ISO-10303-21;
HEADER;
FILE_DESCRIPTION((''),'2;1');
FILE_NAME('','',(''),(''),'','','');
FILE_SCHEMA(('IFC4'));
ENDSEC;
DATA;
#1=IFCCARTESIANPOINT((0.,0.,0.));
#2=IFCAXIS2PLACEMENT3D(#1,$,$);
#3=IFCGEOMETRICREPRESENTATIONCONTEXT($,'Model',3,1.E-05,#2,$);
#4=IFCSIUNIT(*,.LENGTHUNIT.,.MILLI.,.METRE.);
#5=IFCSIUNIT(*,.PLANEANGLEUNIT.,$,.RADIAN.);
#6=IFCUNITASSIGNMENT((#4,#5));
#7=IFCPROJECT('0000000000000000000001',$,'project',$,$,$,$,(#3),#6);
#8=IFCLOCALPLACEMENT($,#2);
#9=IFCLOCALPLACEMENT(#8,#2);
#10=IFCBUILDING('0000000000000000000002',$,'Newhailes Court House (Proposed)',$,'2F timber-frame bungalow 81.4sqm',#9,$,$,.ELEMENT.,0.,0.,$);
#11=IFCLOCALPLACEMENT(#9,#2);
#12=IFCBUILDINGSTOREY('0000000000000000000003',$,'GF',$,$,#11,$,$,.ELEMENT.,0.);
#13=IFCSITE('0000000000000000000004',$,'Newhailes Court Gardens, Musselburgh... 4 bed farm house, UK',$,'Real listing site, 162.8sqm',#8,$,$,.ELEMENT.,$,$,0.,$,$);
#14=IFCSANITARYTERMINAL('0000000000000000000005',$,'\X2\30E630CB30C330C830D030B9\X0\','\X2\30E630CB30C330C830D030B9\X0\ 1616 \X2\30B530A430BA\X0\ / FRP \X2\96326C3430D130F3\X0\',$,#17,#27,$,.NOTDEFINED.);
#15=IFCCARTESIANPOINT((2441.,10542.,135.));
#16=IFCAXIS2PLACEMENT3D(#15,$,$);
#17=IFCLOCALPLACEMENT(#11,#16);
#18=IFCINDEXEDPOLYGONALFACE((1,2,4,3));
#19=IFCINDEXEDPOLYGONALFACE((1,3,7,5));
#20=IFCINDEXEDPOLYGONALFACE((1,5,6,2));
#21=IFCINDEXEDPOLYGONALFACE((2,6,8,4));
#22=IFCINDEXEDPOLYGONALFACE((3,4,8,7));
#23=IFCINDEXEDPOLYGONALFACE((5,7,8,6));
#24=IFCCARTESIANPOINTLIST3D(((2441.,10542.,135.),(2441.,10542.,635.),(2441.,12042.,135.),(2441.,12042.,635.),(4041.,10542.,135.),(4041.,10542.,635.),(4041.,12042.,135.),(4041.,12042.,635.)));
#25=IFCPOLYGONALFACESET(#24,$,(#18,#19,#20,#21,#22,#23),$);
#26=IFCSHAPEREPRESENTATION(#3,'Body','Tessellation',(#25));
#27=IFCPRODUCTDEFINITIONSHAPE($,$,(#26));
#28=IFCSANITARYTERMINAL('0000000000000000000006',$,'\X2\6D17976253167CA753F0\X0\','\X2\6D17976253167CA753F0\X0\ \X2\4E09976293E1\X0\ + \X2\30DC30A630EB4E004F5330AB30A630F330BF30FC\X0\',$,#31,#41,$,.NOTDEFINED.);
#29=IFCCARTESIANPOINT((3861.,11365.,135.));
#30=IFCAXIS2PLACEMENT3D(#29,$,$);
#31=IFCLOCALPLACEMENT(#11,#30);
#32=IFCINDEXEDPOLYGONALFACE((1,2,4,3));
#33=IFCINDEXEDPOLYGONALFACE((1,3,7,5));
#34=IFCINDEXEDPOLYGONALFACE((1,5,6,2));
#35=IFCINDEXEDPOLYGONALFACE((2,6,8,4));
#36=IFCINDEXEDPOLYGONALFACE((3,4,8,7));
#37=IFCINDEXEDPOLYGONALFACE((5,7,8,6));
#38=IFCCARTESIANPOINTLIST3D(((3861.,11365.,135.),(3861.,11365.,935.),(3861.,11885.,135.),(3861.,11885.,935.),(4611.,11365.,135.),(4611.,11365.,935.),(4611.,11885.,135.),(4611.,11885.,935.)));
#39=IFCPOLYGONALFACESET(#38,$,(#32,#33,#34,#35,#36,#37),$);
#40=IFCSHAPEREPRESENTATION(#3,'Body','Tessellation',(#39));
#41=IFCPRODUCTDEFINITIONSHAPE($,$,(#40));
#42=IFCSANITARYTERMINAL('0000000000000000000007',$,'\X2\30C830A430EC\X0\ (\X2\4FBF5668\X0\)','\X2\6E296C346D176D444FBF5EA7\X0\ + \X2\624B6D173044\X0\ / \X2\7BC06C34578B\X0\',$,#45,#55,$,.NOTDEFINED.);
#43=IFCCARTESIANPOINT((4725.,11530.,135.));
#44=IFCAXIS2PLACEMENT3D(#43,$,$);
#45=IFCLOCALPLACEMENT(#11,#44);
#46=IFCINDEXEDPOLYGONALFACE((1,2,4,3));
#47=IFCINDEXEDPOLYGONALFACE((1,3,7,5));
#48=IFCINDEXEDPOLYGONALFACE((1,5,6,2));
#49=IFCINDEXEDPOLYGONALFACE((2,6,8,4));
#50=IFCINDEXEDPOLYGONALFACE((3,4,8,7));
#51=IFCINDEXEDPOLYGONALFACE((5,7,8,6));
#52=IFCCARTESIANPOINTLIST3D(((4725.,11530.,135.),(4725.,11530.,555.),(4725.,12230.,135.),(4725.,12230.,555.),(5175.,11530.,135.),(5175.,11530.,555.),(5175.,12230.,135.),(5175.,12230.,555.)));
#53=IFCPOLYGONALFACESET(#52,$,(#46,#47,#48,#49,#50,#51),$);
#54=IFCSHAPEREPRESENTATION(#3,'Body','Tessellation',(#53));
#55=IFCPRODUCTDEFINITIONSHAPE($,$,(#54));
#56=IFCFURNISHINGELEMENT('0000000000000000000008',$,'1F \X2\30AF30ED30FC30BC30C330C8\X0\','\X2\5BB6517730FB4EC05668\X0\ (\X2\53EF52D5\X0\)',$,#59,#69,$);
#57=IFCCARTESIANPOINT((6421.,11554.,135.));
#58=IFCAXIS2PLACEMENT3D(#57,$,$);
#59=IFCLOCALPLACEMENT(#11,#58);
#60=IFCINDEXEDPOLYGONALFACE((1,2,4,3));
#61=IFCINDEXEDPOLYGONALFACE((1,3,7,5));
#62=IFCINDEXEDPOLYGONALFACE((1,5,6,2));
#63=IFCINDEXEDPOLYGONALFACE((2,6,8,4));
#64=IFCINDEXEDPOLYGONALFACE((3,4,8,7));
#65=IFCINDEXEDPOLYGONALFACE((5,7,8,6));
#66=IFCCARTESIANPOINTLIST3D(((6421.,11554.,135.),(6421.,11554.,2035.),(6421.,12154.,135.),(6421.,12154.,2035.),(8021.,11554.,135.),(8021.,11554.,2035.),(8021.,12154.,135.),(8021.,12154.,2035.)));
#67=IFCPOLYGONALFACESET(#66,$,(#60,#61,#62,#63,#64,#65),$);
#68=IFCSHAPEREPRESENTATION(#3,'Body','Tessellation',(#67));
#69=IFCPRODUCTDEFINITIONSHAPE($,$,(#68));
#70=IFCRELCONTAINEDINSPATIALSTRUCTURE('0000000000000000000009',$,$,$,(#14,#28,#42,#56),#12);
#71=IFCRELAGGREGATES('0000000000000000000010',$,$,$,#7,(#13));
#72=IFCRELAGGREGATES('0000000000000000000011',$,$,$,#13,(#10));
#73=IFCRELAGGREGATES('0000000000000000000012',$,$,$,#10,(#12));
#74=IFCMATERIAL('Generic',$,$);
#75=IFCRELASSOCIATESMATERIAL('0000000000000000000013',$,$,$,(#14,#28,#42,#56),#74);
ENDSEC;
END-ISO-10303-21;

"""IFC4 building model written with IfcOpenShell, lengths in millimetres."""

from ifc_helpers import new_model, si_unit, frame, frame_2d, origin, place, context, project, spatial, rectangle, extrude, material, element, save


model = new_model("IFC4")

# Units and contexts
model_context = context("Model", 3, precision=1e-05, world=origin())
ifc_project = project(units=[si_unit("LENGTHUNIT", "METRE", prefix="MILLI"), si_unit("PLANEANGLEUNIT", "RADIAN")], contexts=[model_context])

# Site, building, storey
site_placement = place(None, origin())
site = spatial("IfcSite", under=ifc_project, at=site_placement, Name="Newhailes Court Gardens, Musselburgh... 4 bed farm house, UK", ObjectType="Real listing site, 162.8sqm", CompositionType="ELEMENT", RefElevation=0.0)
building_placement = place(site_placement, origin())
building = spatial("IfcBuilding", under=site, at=building_placement, Name="Newhailes Court House (Proposed)", ObjectType="2F timber-frame bungalow 81.4sqm", CompositionType="ELEMENT", ElevationOfRefHeight=0.0, ElevationOfTerrain=0.0)
storey_placement = place(building_placement, origin())
storey = spatial("IfcBuildingStorey", under=building, at=storey_placement, Name="GF", CompositionType="ELEMENT", Elevation=0.0)

# Shared definitions
ifc_material_1 = material(Name="Generic")

# Sanitary terminals
sanitary_terminal_1_placement = place(storey_placement, frame((2441.0, 10542.0, 135.0)))
element("IfcSanitaryTerminal", 1, at=sanitary_terminal_1_placement, inside=storey, material=ifc_material_1, Name="ユニットバス", Description="ユニットバス 1616 サイズ / FRP 防水パン", PredefinedType="NOTDEFINED", context=model_context, shape_type="SweptSolid", body=[
    extrude(rectangle(XDim=1600.0, YDim=1500.0, at=frame_2d((800.0, 750.0))), frame((2441.0, 10542.0, 135.0)), (0.0, 0.0, 1.0), 500.0),
])
sanitary_terminal_2_placement = place(storey_placement, frame((3861.0, 11365.0, 135.0)))
element("IfcSanitaryTerminal", 2, at=sanitary_terminal_2_placement, inside=storey, material=ifc_material_1, Name="洗面化粧台", Description="洗面化粧台 三面鏡 + ボウル一体カウンター", PredefinedType="NOTDEFINED", context=model_context, shape_type="SweptSolid", body=[
    extrude(rectangle(XDim=750.0, YDim=520.0, at=frame_2d((375.0, 260.0))), frame((3861.0, 11365.0, 135.0)), (0.0, 0.0, 1.0), 800.0),
])
sanitary_terminal_3_placement = place(storey_placement, frame((4725.0, 11530.0, 135.0)))
element("IfcSanitaryTerminal", 3, at=sanitary_terminal_3_placement, inside=storey, material=ifc_material_1, Name="トイレ (便器)", Description="温水洗浄便座 + 手洗い / 節水型", PredefinedType="NOTDEFINED", context=model_context, shape_type="SweptSolid", body=[
    extrude(rectangle(XDim=450.0, YDim=700.0, at=frame_2d((225.0, 350.0))), frame((4725.0, 11530.0, 135.0)), (0.0, 0.0, 1.0), 420.0),
])

# Furnishing element
furnishing_placement = place(storey_placement, frame((6421.0, 11554.0, 135.0)))
element("IfcFurnishingElement", 4, at=furnishing_placement, inside=storey, material=ifc_material_1, Name="1F クローゼット", Description="家具・什器 (可動)", context=model_context, shape_type="SweptSolid", body=[
    extrude(rectangle(XDim=1600.0, YDim=600.0, at=frame_2d((800.0, 300.0))), frame((6421.0, 11554.0, 135.0)), (0.0, 0.0, 1.0), 1900.0),
])

save(model, "model.ifc")
